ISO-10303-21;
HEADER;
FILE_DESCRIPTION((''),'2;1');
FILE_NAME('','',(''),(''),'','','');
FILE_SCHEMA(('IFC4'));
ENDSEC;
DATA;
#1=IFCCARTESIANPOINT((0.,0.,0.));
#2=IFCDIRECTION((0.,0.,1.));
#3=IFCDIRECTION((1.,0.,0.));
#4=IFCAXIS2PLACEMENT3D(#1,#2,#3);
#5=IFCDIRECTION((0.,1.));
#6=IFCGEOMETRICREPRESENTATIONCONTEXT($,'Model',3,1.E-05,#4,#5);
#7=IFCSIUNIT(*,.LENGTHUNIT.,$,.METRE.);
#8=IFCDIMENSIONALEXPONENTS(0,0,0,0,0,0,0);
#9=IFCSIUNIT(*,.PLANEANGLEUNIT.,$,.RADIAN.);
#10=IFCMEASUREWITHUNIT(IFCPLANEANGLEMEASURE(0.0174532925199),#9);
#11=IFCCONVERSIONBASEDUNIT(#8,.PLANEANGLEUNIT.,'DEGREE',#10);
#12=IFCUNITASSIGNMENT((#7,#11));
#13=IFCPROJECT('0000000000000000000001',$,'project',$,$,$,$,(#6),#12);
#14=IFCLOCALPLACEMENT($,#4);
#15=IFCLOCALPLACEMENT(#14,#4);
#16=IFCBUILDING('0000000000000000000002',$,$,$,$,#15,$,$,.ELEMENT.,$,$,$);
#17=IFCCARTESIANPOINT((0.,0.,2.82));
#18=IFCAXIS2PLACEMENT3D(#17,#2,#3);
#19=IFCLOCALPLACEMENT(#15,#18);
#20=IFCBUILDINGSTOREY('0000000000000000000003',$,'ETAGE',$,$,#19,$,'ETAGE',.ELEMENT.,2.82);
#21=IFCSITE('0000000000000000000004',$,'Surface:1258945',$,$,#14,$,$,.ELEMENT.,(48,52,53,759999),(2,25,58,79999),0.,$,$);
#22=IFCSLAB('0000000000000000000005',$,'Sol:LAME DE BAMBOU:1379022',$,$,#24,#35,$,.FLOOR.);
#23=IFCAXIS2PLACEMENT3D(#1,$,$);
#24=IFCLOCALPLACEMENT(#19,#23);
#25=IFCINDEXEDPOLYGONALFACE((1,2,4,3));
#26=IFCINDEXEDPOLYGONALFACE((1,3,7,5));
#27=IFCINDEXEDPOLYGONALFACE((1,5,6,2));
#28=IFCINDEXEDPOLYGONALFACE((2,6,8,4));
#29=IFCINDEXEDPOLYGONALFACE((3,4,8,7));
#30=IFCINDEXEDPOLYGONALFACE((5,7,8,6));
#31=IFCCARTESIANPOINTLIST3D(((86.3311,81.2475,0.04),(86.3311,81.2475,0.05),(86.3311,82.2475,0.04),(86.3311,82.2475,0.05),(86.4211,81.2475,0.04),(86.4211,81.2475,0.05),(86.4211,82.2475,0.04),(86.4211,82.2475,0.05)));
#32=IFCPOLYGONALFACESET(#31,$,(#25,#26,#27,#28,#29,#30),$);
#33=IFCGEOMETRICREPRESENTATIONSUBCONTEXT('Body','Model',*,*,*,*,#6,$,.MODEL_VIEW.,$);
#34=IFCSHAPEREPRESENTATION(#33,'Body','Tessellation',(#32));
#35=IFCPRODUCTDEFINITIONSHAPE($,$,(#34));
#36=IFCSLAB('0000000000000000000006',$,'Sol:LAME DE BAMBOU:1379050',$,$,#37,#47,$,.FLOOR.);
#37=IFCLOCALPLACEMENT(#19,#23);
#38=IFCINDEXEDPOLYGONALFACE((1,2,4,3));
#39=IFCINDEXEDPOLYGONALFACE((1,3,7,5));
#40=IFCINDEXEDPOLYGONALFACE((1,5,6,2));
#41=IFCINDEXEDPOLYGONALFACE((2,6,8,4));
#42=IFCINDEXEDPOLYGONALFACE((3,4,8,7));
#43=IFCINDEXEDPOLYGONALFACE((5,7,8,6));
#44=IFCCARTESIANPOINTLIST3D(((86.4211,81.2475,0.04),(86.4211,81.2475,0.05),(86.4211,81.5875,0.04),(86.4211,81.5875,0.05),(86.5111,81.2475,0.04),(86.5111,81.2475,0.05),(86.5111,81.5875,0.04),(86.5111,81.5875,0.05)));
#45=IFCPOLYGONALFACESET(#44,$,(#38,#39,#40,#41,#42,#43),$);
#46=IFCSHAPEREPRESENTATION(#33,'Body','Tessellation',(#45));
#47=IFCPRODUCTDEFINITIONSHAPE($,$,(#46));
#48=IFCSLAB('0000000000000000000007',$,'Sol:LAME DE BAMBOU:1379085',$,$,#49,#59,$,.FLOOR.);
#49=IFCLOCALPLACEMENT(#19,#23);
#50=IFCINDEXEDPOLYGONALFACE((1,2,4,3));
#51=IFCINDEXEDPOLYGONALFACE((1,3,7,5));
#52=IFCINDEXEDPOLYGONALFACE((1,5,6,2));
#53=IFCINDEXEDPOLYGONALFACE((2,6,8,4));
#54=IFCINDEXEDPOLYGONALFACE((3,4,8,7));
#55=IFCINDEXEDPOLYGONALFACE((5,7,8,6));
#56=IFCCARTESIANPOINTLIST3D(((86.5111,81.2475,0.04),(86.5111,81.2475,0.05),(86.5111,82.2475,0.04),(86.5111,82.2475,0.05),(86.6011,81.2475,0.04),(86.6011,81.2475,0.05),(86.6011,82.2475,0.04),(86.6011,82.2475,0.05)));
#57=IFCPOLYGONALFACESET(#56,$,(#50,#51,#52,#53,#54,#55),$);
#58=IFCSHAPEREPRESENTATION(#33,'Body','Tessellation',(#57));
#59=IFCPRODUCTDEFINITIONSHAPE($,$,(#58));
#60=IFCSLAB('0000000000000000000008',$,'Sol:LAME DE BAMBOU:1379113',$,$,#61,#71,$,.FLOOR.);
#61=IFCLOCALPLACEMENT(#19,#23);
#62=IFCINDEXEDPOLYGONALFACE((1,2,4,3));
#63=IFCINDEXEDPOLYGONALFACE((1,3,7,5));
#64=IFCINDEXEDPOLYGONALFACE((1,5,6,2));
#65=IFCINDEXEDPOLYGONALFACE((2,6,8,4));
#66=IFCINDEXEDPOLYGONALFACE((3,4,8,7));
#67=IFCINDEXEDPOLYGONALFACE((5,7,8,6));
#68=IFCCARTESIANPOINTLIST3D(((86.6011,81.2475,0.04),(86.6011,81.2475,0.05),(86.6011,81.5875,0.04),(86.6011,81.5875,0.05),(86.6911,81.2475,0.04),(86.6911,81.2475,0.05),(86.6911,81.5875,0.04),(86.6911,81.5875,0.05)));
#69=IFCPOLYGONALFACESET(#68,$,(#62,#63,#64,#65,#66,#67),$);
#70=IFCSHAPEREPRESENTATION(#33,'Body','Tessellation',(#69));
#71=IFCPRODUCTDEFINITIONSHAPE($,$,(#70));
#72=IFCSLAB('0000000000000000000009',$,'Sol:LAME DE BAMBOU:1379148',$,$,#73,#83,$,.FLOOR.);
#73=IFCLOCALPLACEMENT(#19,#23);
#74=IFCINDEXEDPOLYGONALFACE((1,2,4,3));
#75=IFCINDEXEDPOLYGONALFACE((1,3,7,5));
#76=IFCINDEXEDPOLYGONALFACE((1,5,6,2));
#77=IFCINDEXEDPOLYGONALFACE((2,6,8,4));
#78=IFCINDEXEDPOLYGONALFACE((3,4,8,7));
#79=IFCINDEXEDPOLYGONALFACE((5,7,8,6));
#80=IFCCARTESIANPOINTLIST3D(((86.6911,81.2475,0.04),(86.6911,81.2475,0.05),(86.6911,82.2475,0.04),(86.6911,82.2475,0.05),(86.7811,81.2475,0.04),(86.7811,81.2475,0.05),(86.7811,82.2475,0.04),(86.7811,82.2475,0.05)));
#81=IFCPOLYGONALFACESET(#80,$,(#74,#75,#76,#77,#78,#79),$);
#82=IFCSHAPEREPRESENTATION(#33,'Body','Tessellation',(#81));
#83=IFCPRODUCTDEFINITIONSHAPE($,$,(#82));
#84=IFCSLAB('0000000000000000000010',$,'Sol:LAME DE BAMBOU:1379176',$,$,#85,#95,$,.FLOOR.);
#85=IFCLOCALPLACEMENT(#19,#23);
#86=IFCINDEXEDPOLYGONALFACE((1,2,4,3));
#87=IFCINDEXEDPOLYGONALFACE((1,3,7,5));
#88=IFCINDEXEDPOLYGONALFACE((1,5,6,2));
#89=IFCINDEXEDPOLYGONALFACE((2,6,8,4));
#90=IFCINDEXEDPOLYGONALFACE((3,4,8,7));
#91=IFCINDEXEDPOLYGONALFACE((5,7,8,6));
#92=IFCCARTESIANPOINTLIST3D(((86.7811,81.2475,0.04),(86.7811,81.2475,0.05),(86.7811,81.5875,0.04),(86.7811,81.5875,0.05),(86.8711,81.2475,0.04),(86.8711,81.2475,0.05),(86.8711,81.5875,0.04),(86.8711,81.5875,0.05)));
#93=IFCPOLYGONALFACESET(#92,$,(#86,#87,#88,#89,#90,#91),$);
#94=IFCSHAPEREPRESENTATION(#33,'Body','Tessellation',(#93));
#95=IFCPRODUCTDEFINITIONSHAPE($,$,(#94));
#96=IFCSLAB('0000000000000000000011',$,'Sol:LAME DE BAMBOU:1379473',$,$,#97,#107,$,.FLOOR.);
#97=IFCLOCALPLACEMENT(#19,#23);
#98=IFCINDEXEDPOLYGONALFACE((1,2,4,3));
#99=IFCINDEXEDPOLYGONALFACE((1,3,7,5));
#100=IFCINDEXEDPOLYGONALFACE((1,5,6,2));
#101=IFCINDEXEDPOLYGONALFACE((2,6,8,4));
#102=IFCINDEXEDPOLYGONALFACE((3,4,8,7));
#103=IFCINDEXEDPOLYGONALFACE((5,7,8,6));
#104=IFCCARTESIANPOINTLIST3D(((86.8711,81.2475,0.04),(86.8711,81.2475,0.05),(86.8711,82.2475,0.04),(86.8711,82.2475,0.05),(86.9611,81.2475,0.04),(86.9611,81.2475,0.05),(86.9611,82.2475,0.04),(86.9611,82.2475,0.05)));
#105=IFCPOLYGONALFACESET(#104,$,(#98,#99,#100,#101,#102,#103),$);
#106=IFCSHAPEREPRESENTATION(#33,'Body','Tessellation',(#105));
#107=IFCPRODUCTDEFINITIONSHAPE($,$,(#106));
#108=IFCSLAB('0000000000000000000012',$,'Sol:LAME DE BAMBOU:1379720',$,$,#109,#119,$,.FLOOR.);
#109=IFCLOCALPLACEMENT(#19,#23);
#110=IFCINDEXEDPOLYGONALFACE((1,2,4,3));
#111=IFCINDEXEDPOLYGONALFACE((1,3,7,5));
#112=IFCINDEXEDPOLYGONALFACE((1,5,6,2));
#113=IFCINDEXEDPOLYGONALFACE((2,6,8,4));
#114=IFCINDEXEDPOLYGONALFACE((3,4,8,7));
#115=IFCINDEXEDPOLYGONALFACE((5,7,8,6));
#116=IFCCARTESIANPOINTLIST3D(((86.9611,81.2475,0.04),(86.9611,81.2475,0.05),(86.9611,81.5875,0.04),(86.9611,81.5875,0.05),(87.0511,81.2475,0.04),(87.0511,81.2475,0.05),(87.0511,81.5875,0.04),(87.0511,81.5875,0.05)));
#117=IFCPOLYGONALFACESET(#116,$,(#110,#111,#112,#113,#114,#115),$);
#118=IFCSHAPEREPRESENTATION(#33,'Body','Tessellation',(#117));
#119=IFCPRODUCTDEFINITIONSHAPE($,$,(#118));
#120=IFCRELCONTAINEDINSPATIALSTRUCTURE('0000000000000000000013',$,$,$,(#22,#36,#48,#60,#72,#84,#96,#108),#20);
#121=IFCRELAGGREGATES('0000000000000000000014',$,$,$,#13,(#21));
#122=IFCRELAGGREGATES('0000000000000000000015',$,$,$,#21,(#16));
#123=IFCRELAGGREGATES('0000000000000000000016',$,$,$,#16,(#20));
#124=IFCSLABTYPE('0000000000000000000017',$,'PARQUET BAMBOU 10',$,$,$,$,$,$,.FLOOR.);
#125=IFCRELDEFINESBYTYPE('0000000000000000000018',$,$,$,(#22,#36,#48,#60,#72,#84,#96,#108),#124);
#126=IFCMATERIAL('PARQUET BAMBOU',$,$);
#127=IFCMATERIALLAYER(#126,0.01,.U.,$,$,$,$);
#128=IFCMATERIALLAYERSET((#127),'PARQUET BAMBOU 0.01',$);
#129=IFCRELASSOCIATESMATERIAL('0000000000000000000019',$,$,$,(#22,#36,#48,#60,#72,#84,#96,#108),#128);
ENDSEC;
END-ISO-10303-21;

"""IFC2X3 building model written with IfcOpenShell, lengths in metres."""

from ifc_helpers import new_model, entity, si_unit, converted_unit, direction, frame, origin_with_axes, place, context, subcontext, project, spatial, polyline, outline, extrude, material, layer, layer_set, layer_usage, type_object, element, save


model = new_model("IFC2X3")

# Units and contexts
model_context = context("Model", 3, precision=1e-05, world=origin_with_axes(), true_north=direction((0.0, 1.0)))
body_context = subcontext(model_context, "Body", "Model", "MODEL_VIEW")
ifc_project = project(units=[si_unit("LENGTHUNIT", "METRE"), converted_unit("PLANEANGLEUNIT", "DEGREE", entity("IfcPlaneAngleMeasure", 0.0174532925199), si_unit("PLANEANGLEUNIT", "RADIAN"), dimensions=[0, 0, 0, 0, 0, 0, 0])], contexts=[model_context])

# Site, building, storey
site_placement = place(None, origin_with_axes())
site = spatial("IfcSite", under=ifc_project, at=site_placement, Name="Surface:1258945", CompositionType="ELEMENT", RefLatitude=(48, 52, 53, 759999), RefLongitude=(2, 25, 58, 79999), RefElevation=0.0)
building_placement = place(site_placement, origin_with_axes())
building = spatial("IfcBuilding", under=site, at=building_placement, CompositionType="ELEMENT")
storey_placement = place(building_placement, frame((0.0, 0.0, 2.82), z_axis=(0.0, 0.0, 1.0), x_axis=(1.0, 0.0, 0.0)))
storey = spatial("IfcBuildingStorey", under=building, at=storey_placement, Name="ETAGE", LongName="ETAGE", CompositionType="ELEMENT", Elevation=2.82)

# Slabs
ifc_material = material(Name="PARQUET BAMBOU")
ifc_layer = layer(ifc_material, 0.01, ventilated="UNKNOWN")
ifc_layer_set = layer_set([ifc_layer], Name="PARQUET BAMBOU 0.01")
slab_type = type_object("IfcSlabType", Name="PARQUET BAMBOU 10", PredefinedType="FLOOR")
ifc_layer_usage_1 = layer_usage(ifc_layer_set, "AXIS3", "NEGATIVE", 0.01)
slab_1_placement = place(storey_placement, frame((86.3311, 82.2475, 0.05), z_axis=(0.0, 0.0, 1.0), x_axis=(1.0, 0.0, 0.0)))
element("IfcSlab", 1, at=slab_1_placement, inside=storey, type_object=slab_type, material=ifc_layer_usage_1, Name="Sol:LAME DE BAMBOU:1379022", PredefinedType="FLOOR", context=body_context, shape_type="SweptSolid", body=[
    extrude(outline(polyline([(0.0, 0.0), (0.0, -1.0), (0.09, -1.0), (0.09, 0.0), (0.0, 0.0)])), frame((0.0, 0.0, -0.01), z_axis=(0.0, 0.0, 1.0), x_axis=(1.0, 0.0, 0.0)), (0.0, 0.0, 1.0), 0.01),
])
ifc_layer_usage_2 = layer_usage(ifc_layer_set, "AXIS3", "NEGATIVE", 0.01)
slab_2_placement = place(storey_placement, frame((86.4211, 81.5875, 0.05), z_axis=(0.0, 0.0, 1.0), x_axis=(1.0, 0.0, 0.0)))
element("IfcSlab", 2, at=slab_2_placement, inside=storey, type_object=slab_type, material=ifc_layer_usage_2, Name="Sol:LAME DE BAMBOU:1379050", PredefinedType="FLOOR", context=body_context, shape_type="SweptSolid", body=[
    extrude(outline(polyline([(0.0, 0.0), (0.0, -0.34), (0.09, -0.34), (0.09, 0.0), (0.0, 0.0)])), frame((0.0, 0.0, -0.01), z_axis=(0.0, 0.0, 1.0), x_axis=(1.0, 0.0, 0.0)), (0.0, 0.0, 1.0), 0.01),
])
ifc_layer_usage_3 = layer_usage(ifc_layer_set, "AXIS3", "NEGATIVE", 0.01)
slab_3_placement = place(storey_placement, frame((86.5111, 82.2475, 0.05), z_axis=(0.0, 0.0, 1.0), x_axis=(1.0, 0.0, 0.0)))
element("IfcSlab", 3, at=slab_3_placement, inside=storey, type_object=slab_type, material=ifc_layer_usage_3, Name="Sol:LAME DE BAMBOU:1379085", PredefinedType="FLOOR", context=body_context, shape_type="SweptSolid", body=[
    extrude(outline(polyline([(0.0, 0.0), (0.0, -1.0), (0.09, -1.0), (0.09, 0.0), (0.0, 0.0)])), frame((0.0, 0.0, -0.01), z_axis=(0.0, 0.0, 1.0), x_axis=(1.0, 0.0, 0.0)), (0.0, 0.0, 1.0), 0.01),
])
ifc_layer_usage_4 = layer_usage(ifc_layer_set, "AXIS3", "NEGATIVE", 0.01)
slab_4_placement = place(storey_placement, frame((86.6011, 81.5875, 0.05), z_axis=(0.0, 0.0, 1.0), x_axis=(1.0, 0.0, 0.0)))
element("IfcSlab", 4, at=slab_4_placement, inside=storey, type_object=slab_type, material=ifc_layer_usage_4, Name="Sol:LAME DE BAMBOU:1379113", PredefinedType="FLOOR", context=body_context, shape_type="SweptSolid", body=[
    extrude(outline(polyline([(0.0, 0.0), (0.0, -0.34), (0.09, -0.34), (0.09, 0.0), (0.0, 0.0)])), frame((0.0, 0.0, -0.01), z_axis=(0.0, 0.0, 1.0), x_axis=(1.0, 0.0, 0.0)), (0.0, 0.0, 1.0), 0.01),
])
ifc_layer_usage_5 = layer_usage(ifc_layer_set, "AXIS3", "NEGATIVE", 0.01)
slab_5_placement = place(storey_placement, frame((86.6911, 82.2475, 0.05), z_axis=(0.0, 0.0, 1.0), x_axis=(1.0, 0.0, 0.0)))
element("IfcSlab", 5, at=slab_5_placement, inside=storey, type_object=slab_type, material=ifc_layer_usage_5, Name="Sol:LAME DE BAMBOU:1379148", PredefinedType="FLOOR", context=body_context, shape_type="SweptSolid", body=[
    extrude(outline(polyline([(0.0, 0.0), (0.0, -1.0), (0.09, -1.0), (0.09, 0.0), (0.0, 0.0)])), frame((0.0, 0.0, -0.01), z_axis=(0.0, 0.0, 1.0), x_axis=(1.0, 0.0, 0.0)), (0.0, 0.0, 1.0), 0.01),
])
ifc_layer_usage_6 = layer_usage(ifc_layer_set, "AXIS3", "NEGATIVE", 0.01)
slab_6_placement = place(storey_placement, frame((86.7811, 81.5875, 0.05), z_axis=(0.0, 0.0, 1.0), x_axis=(1.0, 0.0, 0.0)))
element("IfcSlab", 6, at=slab_6_placement, inside=storey, type_object=slab_type, material=ifc_layer_usage_6, Name="Sol:LAME DE BAMBOU:1379176", PredefinedType="FLOOR", context=body_context, shape_type="SweptSolid", body=[
    extrude(outline(polyline([(0.0, 0.0), (0.0, -0.34), (0.09, -0.34), (0.09, 0.0), (0.0, 0.0)])), frame((0.0, 0.0, -0.01), z_axis=(0.0, 0.0, 1.0), x_axis=(1.0, 0.0, 0.0)), (0.0, 0.0, 1.0), 0.01),
])
ifc_layer_usage_7 = layer_usage(ifc_layer_set, "AXIS3", "NEGATIVE", 0.01)
slab_7_placement = place(storey_placement, frame((86.8711, 82.2475, 0.05), z_axis=(0.0, 0.0, 1.0), x_axis=(1.0, 0.0, 0.0)))
element("IfcSlab", 7, at=slab_7_placement, inside=storey, type_object=slab_type, material=ifc_layer_usage_7, Name="Sol:LAME DE BAMBOU:1379473", PredefinedType="FLOOR", context=body_context, shape_type="SweptSolid", body=[
    extrude(outline(polyline([(0.0, 0.0), (0.0, -1.0), (0.09, -1.0), (0.09, 0.0), (0.0, 0.0)])), frame((0.0, 0.0, -0.01), z_axis=(0.0, 0.0, 1.0), x_axis=(1.0, 0.0, 0.0)), (0.0, 0.0, 1.0), 0.01),
])
ifc_layer_usage_8 = layer_usage(ifc_layer_set, "AXIS3", "NEGATIVE", 0.01)
slab_8_placement = place(storey_placement, frame((86.9611, 81.5875, 0.05), z_axis=(0.0, 0.0, 1.0), x_axis=(1.0, 0.0, 0.0)))
element("IfcSlab", 8, at=slab_8_placement, inside=storey, type_object=slab_type, material=ifc_layer_usage_8, Name="Sol:LAME DE BAMBOU:1379720", PredefinedType="FLOOR", context=body_context, shape_type="SweptSolid", body=[
    extrude(outline(polyline([(0.0, 0.0), (0.0, -0.34), (0.09, -0.34), (0.09, 0.0), (0.0, 0.0)])), frame((0.0, 0.0, -0.01), z_axis=(0.0, 0.0, 1.0), x_axis=(1.0, 0.0, 0.0)), (0.0, 0.0, 1.0), 0.01),
])

save(model, "model.ifc")
